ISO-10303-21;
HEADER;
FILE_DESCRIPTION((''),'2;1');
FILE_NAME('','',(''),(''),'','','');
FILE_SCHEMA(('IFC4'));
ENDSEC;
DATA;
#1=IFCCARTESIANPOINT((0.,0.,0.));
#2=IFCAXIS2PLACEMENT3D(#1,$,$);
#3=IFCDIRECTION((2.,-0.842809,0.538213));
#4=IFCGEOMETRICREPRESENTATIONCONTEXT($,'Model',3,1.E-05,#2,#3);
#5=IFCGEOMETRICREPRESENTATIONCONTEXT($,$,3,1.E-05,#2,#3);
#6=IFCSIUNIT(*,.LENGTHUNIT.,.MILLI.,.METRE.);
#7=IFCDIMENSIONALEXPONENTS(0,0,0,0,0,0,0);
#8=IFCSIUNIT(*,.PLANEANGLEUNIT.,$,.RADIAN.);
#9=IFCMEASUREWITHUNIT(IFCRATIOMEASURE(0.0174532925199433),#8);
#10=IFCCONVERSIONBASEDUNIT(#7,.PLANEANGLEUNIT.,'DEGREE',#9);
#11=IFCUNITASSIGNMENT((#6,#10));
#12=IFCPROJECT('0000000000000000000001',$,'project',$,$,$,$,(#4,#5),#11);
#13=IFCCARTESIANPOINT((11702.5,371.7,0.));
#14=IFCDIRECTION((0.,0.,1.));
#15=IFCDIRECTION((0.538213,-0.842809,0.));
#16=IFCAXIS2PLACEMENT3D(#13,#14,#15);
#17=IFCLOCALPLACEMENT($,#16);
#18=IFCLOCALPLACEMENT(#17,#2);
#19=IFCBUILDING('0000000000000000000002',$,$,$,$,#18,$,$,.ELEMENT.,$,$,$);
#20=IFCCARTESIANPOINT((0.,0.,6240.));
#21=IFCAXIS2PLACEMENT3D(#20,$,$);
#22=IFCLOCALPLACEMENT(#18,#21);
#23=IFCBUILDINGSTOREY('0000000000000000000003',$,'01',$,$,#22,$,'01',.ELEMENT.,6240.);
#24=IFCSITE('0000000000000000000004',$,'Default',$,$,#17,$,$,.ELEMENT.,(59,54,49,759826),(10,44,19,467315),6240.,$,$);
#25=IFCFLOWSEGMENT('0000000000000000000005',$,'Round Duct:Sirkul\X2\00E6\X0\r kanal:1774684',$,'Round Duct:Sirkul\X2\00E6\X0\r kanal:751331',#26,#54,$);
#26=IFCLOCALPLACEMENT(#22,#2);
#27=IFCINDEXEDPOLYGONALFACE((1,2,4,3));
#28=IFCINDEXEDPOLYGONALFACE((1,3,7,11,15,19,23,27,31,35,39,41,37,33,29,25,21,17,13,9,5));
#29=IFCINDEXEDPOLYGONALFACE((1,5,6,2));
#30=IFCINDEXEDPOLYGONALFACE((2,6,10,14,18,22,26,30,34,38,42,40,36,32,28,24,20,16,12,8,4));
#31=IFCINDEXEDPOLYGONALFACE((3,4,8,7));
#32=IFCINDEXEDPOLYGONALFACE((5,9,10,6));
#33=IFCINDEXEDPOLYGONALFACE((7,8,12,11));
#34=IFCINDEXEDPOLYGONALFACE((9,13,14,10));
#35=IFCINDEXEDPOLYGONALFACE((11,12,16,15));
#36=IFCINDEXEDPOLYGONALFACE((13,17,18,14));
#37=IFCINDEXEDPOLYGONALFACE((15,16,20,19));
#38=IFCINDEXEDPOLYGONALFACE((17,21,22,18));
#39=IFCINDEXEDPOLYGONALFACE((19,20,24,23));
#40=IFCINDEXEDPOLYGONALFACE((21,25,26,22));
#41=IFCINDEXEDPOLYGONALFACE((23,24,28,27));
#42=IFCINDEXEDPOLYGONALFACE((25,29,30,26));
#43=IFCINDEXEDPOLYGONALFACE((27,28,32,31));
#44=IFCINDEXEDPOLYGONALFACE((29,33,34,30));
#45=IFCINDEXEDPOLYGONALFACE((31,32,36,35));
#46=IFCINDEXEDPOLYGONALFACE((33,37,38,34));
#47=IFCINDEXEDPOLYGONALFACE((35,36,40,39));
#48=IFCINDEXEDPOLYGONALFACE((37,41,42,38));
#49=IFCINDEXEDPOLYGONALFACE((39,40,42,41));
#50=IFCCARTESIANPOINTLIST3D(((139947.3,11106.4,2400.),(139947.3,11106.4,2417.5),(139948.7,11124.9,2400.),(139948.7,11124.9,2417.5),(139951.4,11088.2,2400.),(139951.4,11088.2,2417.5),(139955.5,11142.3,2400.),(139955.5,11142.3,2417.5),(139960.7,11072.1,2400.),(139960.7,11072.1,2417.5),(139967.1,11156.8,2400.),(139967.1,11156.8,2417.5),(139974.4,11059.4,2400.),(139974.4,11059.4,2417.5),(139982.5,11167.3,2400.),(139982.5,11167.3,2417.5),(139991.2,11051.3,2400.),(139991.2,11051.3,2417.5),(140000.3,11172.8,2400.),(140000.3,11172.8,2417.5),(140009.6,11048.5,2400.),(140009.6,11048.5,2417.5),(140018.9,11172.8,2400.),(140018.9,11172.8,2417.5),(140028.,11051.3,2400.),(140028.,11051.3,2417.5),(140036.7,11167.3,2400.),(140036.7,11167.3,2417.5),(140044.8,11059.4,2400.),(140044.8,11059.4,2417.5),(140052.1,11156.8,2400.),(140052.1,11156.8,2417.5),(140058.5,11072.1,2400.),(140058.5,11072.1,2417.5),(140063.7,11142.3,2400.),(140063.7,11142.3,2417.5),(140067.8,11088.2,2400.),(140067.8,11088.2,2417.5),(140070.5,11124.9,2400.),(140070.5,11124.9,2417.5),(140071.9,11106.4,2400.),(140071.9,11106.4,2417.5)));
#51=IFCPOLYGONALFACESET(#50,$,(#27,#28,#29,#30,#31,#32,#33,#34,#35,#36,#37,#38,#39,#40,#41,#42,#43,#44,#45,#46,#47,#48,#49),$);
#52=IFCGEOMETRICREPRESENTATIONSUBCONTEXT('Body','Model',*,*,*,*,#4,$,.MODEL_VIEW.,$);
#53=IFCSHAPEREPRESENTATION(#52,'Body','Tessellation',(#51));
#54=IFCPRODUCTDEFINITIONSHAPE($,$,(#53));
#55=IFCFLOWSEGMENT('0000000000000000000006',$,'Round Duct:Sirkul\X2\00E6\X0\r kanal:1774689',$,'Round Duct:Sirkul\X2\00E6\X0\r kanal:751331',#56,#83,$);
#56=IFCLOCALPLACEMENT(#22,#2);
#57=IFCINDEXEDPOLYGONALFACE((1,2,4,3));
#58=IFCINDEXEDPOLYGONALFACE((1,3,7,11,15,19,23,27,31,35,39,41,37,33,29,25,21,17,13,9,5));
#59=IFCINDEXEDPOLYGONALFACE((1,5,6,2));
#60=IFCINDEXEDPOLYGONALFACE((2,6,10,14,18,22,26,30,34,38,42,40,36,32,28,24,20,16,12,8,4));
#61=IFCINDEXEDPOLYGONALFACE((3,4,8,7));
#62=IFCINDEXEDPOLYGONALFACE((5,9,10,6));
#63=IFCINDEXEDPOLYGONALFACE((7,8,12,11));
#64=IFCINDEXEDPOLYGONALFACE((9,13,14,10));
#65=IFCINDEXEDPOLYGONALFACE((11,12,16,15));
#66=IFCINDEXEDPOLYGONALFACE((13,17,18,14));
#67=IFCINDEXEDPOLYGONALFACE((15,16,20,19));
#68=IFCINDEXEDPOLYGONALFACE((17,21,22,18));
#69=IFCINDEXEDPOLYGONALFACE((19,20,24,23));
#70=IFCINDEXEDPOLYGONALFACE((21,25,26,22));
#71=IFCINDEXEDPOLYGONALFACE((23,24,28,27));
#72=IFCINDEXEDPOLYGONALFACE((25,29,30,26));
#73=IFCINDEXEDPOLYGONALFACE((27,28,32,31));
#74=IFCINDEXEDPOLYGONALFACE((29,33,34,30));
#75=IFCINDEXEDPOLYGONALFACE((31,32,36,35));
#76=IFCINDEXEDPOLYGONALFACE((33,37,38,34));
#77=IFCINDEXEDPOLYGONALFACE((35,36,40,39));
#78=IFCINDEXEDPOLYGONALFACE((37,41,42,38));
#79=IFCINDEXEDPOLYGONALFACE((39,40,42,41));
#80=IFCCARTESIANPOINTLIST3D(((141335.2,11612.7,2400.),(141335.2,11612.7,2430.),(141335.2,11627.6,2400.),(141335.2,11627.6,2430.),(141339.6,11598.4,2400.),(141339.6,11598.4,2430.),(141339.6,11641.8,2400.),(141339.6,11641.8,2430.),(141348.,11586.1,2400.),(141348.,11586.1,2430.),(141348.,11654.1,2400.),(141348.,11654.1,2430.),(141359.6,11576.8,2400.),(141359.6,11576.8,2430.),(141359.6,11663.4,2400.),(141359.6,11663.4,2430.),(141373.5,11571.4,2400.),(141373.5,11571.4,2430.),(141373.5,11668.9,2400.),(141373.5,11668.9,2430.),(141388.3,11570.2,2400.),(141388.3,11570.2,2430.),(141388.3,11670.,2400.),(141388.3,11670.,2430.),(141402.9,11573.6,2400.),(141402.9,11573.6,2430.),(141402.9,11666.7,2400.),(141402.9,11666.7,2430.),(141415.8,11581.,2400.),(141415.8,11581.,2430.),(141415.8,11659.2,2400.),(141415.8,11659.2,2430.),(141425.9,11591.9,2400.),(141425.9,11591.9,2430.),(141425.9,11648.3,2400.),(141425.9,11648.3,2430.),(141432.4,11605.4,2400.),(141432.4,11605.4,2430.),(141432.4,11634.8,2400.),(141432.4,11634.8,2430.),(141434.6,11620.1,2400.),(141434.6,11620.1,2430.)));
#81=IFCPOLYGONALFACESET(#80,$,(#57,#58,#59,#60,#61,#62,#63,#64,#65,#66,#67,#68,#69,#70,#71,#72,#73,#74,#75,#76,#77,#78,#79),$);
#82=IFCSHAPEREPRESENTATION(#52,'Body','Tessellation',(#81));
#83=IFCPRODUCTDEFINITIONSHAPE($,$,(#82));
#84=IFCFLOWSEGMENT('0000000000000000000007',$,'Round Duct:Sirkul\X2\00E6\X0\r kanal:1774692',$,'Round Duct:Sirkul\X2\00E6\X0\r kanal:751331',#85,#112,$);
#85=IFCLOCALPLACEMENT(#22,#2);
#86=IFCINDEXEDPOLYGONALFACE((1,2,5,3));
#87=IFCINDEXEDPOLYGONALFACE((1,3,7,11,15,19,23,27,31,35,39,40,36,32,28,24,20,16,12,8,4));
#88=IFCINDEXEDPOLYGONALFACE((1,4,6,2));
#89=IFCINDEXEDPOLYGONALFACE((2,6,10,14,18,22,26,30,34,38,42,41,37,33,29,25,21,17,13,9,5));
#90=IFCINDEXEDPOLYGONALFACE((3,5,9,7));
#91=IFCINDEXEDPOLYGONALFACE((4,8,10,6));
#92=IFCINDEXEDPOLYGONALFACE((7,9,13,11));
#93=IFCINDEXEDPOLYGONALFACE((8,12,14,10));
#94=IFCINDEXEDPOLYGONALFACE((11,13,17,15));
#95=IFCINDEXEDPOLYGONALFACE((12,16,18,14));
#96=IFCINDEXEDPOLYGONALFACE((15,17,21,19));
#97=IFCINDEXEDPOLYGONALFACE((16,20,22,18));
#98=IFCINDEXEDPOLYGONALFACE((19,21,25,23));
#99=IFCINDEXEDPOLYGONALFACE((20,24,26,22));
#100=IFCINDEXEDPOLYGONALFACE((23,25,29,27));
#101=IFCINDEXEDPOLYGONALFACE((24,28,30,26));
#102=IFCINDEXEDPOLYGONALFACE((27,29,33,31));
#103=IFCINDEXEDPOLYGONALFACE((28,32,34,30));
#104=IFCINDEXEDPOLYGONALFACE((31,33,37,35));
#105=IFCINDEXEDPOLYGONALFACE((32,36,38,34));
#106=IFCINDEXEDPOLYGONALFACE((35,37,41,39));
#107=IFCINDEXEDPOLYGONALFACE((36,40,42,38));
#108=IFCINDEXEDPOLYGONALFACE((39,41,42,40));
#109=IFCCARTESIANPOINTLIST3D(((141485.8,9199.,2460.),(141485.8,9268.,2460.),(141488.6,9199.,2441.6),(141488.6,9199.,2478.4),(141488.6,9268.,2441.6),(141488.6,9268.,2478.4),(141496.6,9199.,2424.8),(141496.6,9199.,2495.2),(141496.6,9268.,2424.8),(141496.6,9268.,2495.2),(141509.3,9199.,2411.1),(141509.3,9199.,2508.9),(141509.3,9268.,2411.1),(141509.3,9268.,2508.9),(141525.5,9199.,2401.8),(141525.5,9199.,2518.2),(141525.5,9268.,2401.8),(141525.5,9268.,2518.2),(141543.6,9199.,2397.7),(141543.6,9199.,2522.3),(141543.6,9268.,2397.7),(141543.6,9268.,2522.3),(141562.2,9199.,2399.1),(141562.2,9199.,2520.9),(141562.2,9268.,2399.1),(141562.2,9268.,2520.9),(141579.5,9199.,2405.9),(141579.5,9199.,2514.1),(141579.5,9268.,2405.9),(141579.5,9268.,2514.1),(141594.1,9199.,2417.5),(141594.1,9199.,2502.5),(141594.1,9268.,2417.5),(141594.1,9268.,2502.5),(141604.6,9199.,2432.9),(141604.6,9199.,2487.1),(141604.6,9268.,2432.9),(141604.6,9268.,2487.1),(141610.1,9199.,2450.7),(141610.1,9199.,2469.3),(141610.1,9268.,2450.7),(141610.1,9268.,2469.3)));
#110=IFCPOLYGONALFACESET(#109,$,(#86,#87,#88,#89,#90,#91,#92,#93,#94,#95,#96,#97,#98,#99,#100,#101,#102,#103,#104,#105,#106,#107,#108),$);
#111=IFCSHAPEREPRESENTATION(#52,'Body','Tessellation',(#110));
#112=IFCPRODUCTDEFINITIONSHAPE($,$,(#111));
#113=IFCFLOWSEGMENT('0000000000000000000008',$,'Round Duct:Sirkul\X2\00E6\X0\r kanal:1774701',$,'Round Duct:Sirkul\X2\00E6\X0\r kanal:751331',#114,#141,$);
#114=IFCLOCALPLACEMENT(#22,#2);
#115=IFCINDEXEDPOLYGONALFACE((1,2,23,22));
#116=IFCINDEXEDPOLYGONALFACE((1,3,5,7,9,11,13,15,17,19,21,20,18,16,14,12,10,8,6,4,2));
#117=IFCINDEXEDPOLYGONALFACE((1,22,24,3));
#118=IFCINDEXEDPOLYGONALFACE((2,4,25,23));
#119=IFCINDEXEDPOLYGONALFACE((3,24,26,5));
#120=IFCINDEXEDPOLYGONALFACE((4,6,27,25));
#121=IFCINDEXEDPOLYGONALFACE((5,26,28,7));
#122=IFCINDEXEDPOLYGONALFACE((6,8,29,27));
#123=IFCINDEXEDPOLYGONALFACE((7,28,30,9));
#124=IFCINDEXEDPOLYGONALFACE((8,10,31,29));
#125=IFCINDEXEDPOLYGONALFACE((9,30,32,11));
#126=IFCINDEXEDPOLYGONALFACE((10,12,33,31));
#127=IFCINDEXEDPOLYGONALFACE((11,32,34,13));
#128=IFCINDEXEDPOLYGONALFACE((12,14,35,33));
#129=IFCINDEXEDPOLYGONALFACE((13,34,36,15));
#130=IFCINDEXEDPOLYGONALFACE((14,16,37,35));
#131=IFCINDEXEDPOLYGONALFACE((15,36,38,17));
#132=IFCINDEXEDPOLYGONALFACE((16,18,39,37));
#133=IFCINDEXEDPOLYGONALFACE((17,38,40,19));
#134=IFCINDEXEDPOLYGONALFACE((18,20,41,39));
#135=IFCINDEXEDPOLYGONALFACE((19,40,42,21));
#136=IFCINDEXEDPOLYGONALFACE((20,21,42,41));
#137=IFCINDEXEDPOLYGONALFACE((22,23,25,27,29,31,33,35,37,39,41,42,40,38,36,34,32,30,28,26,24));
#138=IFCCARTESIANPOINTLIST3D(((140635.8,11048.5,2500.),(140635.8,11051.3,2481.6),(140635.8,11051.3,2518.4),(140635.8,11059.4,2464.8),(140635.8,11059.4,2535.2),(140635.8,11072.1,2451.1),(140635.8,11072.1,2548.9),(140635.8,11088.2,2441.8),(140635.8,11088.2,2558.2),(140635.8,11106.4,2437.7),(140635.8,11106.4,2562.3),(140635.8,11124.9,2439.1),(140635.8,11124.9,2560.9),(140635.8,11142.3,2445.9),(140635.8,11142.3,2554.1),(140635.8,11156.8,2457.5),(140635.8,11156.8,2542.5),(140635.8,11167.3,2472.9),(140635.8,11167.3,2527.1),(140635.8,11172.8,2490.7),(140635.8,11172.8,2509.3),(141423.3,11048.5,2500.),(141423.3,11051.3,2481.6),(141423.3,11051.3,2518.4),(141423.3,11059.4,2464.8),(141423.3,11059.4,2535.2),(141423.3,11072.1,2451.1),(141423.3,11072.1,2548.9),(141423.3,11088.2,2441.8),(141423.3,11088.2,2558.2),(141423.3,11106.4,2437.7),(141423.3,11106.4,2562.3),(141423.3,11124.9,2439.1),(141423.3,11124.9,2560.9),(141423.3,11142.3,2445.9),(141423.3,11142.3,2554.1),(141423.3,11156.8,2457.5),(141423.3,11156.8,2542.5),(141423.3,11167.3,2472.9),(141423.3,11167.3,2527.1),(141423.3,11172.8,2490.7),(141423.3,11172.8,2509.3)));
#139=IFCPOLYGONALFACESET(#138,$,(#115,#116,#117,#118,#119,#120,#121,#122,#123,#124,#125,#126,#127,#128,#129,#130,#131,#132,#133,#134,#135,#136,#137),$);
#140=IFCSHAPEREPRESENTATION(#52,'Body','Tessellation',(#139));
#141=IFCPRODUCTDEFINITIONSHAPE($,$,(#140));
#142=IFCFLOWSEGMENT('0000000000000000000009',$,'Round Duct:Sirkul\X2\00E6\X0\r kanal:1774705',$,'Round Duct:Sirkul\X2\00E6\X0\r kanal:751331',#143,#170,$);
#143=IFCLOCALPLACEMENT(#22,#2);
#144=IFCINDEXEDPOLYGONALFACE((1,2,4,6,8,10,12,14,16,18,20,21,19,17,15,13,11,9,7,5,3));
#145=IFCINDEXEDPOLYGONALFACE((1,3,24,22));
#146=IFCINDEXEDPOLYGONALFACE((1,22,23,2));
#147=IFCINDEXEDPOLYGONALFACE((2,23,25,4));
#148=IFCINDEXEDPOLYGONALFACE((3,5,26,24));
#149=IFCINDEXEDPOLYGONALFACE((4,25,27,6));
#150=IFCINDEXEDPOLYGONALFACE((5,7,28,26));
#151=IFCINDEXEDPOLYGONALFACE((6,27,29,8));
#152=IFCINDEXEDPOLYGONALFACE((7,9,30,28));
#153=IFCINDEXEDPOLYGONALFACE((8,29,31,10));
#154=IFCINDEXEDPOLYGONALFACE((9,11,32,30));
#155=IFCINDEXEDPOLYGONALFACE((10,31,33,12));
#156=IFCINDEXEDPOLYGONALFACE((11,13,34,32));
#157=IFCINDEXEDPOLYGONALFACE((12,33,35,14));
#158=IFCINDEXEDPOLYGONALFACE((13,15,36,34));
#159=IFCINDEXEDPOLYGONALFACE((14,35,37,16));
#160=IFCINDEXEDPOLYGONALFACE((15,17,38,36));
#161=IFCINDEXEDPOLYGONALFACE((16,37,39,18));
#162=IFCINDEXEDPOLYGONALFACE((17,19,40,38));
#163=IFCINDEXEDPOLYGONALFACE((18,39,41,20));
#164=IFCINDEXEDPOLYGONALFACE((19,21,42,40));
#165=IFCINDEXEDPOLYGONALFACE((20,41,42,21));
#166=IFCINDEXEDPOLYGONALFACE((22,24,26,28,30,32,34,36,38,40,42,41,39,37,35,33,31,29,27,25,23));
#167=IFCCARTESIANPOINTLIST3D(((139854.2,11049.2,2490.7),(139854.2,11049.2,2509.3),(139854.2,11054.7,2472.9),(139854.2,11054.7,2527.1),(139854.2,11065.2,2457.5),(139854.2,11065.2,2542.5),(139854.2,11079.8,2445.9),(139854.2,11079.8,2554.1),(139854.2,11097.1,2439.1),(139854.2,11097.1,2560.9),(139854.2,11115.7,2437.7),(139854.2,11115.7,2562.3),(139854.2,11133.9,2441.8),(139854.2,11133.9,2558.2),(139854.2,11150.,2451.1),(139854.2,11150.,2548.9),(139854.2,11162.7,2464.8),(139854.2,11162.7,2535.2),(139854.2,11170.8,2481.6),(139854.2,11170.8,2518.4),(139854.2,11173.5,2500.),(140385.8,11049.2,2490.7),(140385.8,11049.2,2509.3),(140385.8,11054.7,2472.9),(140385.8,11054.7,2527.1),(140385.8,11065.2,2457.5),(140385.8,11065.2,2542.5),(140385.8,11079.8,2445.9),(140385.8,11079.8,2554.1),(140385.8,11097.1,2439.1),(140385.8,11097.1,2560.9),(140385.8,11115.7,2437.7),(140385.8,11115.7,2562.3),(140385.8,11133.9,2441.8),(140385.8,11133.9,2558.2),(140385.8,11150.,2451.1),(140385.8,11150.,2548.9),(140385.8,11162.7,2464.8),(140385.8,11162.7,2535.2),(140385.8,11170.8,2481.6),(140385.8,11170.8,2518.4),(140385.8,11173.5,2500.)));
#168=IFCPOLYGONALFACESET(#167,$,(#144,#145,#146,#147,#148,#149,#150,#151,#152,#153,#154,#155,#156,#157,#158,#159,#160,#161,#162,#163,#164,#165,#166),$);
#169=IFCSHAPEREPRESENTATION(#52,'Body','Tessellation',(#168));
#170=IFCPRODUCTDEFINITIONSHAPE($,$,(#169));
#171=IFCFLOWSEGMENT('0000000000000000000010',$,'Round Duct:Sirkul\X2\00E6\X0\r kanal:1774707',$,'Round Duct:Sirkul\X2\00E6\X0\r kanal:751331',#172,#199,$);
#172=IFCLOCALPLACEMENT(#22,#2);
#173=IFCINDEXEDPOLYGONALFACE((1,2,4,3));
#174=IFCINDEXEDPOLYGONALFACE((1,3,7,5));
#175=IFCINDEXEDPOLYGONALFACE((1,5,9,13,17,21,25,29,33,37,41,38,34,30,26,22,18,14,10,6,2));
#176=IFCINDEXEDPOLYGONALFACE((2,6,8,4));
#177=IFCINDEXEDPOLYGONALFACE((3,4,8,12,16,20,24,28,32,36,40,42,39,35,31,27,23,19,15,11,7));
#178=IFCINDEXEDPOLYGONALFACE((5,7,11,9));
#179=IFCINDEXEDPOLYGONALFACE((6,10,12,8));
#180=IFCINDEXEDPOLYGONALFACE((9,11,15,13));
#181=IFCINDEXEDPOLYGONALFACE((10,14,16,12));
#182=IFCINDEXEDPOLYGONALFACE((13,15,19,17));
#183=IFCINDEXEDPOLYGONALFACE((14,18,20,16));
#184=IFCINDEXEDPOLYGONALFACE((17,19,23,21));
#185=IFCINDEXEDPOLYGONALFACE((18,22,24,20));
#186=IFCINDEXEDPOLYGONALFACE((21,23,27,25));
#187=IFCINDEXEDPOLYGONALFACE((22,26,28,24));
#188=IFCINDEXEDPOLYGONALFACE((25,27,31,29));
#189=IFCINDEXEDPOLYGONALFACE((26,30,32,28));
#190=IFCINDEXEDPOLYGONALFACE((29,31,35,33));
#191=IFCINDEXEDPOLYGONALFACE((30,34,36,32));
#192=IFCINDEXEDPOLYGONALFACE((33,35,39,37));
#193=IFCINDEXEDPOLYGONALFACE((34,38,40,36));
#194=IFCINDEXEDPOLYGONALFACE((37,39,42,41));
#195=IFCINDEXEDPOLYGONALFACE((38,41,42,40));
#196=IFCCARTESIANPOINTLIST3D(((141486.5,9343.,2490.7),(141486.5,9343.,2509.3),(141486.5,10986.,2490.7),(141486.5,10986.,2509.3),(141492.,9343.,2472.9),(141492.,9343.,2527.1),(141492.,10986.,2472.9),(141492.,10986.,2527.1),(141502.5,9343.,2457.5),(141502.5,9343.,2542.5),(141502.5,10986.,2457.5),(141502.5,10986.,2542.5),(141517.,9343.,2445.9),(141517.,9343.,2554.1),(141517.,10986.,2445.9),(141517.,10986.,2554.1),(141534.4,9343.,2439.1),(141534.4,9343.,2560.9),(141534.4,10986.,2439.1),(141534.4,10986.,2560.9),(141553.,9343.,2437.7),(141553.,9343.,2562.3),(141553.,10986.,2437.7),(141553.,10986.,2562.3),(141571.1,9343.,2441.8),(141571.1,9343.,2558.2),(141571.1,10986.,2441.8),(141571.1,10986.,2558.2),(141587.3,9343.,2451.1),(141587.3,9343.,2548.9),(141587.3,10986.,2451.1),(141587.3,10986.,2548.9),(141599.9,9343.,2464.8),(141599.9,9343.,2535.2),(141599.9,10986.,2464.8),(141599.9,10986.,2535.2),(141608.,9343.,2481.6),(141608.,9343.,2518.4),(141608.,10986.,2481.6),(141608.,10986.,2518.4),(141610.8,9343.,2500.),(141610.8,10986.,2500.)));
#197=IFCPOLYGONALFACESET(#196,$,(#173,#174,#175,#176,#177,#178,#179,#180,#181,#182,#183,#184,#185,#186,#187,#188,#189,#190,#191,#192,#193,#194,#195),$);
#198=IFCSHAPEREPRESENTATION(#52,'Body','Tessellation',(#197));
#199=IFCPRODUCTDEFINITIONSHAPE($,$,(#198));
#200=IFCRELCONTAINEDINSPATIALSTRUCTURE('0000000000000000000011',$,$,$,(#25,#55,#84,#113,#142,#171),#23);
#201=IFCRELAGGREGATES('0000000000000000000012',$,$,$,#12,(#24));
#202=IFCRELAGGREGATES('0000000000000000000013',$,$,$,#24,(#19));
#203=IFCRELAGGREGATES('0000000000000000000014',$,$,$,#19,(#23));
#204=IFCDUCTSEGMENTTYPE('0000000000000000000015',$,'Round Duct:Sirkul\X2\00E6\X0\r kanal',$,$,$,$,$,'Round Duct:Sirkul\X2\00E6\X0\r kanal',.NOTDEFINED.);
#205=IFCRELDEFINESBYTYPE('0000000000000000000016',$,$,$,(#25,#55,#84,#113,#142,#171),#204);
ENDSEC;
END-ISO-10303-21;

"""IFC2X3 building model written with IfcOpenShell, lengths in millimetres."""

from ifc_helpers import new_model, entity, si_unit, converted_unit, direction, frame, frame_2d, origin, origin_2d_with_axis, place, context, subcontext, project, spatial, circle, extrude, type_object, element, save


model = new_model("IFC2X3")

# Units and contexts
model_context = context("Model", 3, precision=1e-05, world=origin(), true_north=direction((2.0, -0.842809, 0.538213)))
context_of_model = context(None, 3, precision=1e-05, world=origin(), true_north=direction((2.0, -0.842809, 0.538213)))
body_context = subcontext(model_context, "Body", "Model", "MODEL_VIEW")
ifc_project = project(units=[si_unit("LENGTHUNIT", "METRE", prefix="MILLI"), converted_unit("PLANEANGLEUNIT", "DEGREE", entity("IfcRatioMeasure", 0.0174532925199433), si_unit("PLANEANGLEUNIT", "RADIAN"), dimensions=[0, 0, 0, 0, 0, 0, 0])], contexts=[model_context, context_of_model])

# Site, building, storey
site_placement = place(None, frame((11702.5, 371.7, 0.0), z_axis=(0.0, 0.0, 1.0), x_axis=(0.538213, -0.842809, 0.0)))
site = spatial("IfcSite", under=ifc_project, at=site_placement, Name="Default", CompositionType="ELEMENT", RefLatitude=(59, 54, 49, 759826), RefLongitude=(10, 44, 19, 467315), RefElevation=6240.0)
building_placement = place(site_placement, origin())
building = spatial("IfcBuilding", under=site, at=building_placement, CompositionType="ELEMENT")
storey_placement = place(building_placement, frame((0.0, 0.0, 6240.0)))
storey = spatial("IfcBuildingStorey", under=building, at=storey_placement, Name="01", LongName="01", CompositionType="ELEMENT", Elevation=6240.0)

# Flow segments
duct_segment_type = type_object("IfcDuctSegmentType", Name="Round Duct:Sirkulær kanal", ElementType="Round Duct:Sirkulær kanal", PredefinedType="NOTDEFINED")
flow_segment_1_placement = place(storey_placement, origin())
element("IfcFlowSegment", 1, at=flow_segment_1_placement, inside=storey, type_object=duct_segment_type, Name="Round Duct:Sirkulær kanal:1774684", ObjectType="Round Duct:Sirkulær kanal:751331", context=body_context, shape_type="SweptSolid", body=[
    extrude(circle(Radius=62.5, at=frame_2d((0.0, 0.0), x_axis=(1.0, 0.0))), frame((140009.6, 11111.0, 2400.0), z_axis=(0.0, 0.0, 1.0), x_axis=(0.0, -1.0, 0.0)), (0.0, 0.0, 1.0), 17.5),
])
flow_segment_2_placement = place(storey_placement, origin())
element("IfcFlowSegment", 2, at=flow_segment_2_placement, inside=storey, type_object=duct_segment_type, Name="Round Duct:Sirkulær kanal:1774689", ObjectType="Round Duct:Sirkulær kanal:751331", context=body_context, shape_type="SweptSolid", body=[
    extrude(circle(Radius=50.0, at=frame_2d((0.0, 0.0), x_axis=(1.0, 0.0))), frame((141384.6, 11620.1, 2400.0)), (0.0, 0.0, 1.0), 30.0),
])
flow_segment_3_placement = place(storey_placement, origin())
element("IfcFlowSegment", 3, at=flow_segment_3_placement, inside=storey, type_object=duct_segment_type, Name="Round Duct:Sirkulær kanal:1774692", ObjectType="Round Duct:Sirkulær kanal:751331", context=body_context, shape_type="SweptSolid", body=[
    extrude(circle(Radius=62.5, at=origin_2d_with_axis()), frame((141548.3, 9199.0, 2460.0), z_axis=(0.0, 1.0, 0.0), x_axis=(-1.0, 0.0, 0.0)), (0.0, 0.0, 1.0), 69.0),
])
flow_segment_4_placement = place(storey_placement, origin())
element("IfcFlowSegment", 4, at=flow_segment_4_placement, inside=storey, type_object=duct_segment_type, Name="Round Duct:Sirkulær kanal:1774701", ObjectType="Round Duct:Sirkulær kanal:751331", context=body_context, shape_type="SweptSolid", body=[
    extrude(circle(Radius=62.5, at=origin_2d_with_axis()), frame((140635.8, 11111.0, 2500.0), z_axis=(1.0, 0.0, 0.0), x_axis=(0.0, -1.0, 0.0)), (0.0, 0.0, 1.0), 787.5),
])
flow_segment_5_placement = place(storey_placement, origin())
element("IfcFlowSegment", 5, at=flow_segment_5_placement, inside=storey, type_object=duct_segment_type, Name="Round Duct:Sirkulær kanal:1774705", ObjectType="Round Duct:Sirkulær kanal:751331", context=body_context, shape_type="SweptSolid", body=[
    extrude(circle(Radius=62.5, at=frame_2d((0.0, 0.0), x_axis=(1.0, 0.0))), frame((139854.2, 11111.0, 2500.0), z_axis=(1.0, 0.0, 0.0), x_axis=(0.0, 1.0, 0.0)), (0.0, 0.0, 1.0), 531.6),
])
flow_segment_6_placement = place(storey_placement, origin())
element("IfcFlowSegment", 6, at=flow_segment_6_placement, inside=storey, type_object=duct_segment_type, Name="Round Duct:Sirkulær kanal:1774707", ObjectType="Round Duct:Sirkulær kanal:751331", context=body_context, shape_type="SweptSolid", body=[
    extrude(circle(Radius=62.5, at=frame_2d((0.0, 0.0), x_axis=(1.0, 0.0))), frame((141548.3, 9343.0, 2500.0), z_axis=(0.0, 1.0, 0.0), x_axis=(1.0, 0.0, 0.0)), (0.0, 0.0, 1.0), 1643.0),
])

save(model, "model.ifc")
